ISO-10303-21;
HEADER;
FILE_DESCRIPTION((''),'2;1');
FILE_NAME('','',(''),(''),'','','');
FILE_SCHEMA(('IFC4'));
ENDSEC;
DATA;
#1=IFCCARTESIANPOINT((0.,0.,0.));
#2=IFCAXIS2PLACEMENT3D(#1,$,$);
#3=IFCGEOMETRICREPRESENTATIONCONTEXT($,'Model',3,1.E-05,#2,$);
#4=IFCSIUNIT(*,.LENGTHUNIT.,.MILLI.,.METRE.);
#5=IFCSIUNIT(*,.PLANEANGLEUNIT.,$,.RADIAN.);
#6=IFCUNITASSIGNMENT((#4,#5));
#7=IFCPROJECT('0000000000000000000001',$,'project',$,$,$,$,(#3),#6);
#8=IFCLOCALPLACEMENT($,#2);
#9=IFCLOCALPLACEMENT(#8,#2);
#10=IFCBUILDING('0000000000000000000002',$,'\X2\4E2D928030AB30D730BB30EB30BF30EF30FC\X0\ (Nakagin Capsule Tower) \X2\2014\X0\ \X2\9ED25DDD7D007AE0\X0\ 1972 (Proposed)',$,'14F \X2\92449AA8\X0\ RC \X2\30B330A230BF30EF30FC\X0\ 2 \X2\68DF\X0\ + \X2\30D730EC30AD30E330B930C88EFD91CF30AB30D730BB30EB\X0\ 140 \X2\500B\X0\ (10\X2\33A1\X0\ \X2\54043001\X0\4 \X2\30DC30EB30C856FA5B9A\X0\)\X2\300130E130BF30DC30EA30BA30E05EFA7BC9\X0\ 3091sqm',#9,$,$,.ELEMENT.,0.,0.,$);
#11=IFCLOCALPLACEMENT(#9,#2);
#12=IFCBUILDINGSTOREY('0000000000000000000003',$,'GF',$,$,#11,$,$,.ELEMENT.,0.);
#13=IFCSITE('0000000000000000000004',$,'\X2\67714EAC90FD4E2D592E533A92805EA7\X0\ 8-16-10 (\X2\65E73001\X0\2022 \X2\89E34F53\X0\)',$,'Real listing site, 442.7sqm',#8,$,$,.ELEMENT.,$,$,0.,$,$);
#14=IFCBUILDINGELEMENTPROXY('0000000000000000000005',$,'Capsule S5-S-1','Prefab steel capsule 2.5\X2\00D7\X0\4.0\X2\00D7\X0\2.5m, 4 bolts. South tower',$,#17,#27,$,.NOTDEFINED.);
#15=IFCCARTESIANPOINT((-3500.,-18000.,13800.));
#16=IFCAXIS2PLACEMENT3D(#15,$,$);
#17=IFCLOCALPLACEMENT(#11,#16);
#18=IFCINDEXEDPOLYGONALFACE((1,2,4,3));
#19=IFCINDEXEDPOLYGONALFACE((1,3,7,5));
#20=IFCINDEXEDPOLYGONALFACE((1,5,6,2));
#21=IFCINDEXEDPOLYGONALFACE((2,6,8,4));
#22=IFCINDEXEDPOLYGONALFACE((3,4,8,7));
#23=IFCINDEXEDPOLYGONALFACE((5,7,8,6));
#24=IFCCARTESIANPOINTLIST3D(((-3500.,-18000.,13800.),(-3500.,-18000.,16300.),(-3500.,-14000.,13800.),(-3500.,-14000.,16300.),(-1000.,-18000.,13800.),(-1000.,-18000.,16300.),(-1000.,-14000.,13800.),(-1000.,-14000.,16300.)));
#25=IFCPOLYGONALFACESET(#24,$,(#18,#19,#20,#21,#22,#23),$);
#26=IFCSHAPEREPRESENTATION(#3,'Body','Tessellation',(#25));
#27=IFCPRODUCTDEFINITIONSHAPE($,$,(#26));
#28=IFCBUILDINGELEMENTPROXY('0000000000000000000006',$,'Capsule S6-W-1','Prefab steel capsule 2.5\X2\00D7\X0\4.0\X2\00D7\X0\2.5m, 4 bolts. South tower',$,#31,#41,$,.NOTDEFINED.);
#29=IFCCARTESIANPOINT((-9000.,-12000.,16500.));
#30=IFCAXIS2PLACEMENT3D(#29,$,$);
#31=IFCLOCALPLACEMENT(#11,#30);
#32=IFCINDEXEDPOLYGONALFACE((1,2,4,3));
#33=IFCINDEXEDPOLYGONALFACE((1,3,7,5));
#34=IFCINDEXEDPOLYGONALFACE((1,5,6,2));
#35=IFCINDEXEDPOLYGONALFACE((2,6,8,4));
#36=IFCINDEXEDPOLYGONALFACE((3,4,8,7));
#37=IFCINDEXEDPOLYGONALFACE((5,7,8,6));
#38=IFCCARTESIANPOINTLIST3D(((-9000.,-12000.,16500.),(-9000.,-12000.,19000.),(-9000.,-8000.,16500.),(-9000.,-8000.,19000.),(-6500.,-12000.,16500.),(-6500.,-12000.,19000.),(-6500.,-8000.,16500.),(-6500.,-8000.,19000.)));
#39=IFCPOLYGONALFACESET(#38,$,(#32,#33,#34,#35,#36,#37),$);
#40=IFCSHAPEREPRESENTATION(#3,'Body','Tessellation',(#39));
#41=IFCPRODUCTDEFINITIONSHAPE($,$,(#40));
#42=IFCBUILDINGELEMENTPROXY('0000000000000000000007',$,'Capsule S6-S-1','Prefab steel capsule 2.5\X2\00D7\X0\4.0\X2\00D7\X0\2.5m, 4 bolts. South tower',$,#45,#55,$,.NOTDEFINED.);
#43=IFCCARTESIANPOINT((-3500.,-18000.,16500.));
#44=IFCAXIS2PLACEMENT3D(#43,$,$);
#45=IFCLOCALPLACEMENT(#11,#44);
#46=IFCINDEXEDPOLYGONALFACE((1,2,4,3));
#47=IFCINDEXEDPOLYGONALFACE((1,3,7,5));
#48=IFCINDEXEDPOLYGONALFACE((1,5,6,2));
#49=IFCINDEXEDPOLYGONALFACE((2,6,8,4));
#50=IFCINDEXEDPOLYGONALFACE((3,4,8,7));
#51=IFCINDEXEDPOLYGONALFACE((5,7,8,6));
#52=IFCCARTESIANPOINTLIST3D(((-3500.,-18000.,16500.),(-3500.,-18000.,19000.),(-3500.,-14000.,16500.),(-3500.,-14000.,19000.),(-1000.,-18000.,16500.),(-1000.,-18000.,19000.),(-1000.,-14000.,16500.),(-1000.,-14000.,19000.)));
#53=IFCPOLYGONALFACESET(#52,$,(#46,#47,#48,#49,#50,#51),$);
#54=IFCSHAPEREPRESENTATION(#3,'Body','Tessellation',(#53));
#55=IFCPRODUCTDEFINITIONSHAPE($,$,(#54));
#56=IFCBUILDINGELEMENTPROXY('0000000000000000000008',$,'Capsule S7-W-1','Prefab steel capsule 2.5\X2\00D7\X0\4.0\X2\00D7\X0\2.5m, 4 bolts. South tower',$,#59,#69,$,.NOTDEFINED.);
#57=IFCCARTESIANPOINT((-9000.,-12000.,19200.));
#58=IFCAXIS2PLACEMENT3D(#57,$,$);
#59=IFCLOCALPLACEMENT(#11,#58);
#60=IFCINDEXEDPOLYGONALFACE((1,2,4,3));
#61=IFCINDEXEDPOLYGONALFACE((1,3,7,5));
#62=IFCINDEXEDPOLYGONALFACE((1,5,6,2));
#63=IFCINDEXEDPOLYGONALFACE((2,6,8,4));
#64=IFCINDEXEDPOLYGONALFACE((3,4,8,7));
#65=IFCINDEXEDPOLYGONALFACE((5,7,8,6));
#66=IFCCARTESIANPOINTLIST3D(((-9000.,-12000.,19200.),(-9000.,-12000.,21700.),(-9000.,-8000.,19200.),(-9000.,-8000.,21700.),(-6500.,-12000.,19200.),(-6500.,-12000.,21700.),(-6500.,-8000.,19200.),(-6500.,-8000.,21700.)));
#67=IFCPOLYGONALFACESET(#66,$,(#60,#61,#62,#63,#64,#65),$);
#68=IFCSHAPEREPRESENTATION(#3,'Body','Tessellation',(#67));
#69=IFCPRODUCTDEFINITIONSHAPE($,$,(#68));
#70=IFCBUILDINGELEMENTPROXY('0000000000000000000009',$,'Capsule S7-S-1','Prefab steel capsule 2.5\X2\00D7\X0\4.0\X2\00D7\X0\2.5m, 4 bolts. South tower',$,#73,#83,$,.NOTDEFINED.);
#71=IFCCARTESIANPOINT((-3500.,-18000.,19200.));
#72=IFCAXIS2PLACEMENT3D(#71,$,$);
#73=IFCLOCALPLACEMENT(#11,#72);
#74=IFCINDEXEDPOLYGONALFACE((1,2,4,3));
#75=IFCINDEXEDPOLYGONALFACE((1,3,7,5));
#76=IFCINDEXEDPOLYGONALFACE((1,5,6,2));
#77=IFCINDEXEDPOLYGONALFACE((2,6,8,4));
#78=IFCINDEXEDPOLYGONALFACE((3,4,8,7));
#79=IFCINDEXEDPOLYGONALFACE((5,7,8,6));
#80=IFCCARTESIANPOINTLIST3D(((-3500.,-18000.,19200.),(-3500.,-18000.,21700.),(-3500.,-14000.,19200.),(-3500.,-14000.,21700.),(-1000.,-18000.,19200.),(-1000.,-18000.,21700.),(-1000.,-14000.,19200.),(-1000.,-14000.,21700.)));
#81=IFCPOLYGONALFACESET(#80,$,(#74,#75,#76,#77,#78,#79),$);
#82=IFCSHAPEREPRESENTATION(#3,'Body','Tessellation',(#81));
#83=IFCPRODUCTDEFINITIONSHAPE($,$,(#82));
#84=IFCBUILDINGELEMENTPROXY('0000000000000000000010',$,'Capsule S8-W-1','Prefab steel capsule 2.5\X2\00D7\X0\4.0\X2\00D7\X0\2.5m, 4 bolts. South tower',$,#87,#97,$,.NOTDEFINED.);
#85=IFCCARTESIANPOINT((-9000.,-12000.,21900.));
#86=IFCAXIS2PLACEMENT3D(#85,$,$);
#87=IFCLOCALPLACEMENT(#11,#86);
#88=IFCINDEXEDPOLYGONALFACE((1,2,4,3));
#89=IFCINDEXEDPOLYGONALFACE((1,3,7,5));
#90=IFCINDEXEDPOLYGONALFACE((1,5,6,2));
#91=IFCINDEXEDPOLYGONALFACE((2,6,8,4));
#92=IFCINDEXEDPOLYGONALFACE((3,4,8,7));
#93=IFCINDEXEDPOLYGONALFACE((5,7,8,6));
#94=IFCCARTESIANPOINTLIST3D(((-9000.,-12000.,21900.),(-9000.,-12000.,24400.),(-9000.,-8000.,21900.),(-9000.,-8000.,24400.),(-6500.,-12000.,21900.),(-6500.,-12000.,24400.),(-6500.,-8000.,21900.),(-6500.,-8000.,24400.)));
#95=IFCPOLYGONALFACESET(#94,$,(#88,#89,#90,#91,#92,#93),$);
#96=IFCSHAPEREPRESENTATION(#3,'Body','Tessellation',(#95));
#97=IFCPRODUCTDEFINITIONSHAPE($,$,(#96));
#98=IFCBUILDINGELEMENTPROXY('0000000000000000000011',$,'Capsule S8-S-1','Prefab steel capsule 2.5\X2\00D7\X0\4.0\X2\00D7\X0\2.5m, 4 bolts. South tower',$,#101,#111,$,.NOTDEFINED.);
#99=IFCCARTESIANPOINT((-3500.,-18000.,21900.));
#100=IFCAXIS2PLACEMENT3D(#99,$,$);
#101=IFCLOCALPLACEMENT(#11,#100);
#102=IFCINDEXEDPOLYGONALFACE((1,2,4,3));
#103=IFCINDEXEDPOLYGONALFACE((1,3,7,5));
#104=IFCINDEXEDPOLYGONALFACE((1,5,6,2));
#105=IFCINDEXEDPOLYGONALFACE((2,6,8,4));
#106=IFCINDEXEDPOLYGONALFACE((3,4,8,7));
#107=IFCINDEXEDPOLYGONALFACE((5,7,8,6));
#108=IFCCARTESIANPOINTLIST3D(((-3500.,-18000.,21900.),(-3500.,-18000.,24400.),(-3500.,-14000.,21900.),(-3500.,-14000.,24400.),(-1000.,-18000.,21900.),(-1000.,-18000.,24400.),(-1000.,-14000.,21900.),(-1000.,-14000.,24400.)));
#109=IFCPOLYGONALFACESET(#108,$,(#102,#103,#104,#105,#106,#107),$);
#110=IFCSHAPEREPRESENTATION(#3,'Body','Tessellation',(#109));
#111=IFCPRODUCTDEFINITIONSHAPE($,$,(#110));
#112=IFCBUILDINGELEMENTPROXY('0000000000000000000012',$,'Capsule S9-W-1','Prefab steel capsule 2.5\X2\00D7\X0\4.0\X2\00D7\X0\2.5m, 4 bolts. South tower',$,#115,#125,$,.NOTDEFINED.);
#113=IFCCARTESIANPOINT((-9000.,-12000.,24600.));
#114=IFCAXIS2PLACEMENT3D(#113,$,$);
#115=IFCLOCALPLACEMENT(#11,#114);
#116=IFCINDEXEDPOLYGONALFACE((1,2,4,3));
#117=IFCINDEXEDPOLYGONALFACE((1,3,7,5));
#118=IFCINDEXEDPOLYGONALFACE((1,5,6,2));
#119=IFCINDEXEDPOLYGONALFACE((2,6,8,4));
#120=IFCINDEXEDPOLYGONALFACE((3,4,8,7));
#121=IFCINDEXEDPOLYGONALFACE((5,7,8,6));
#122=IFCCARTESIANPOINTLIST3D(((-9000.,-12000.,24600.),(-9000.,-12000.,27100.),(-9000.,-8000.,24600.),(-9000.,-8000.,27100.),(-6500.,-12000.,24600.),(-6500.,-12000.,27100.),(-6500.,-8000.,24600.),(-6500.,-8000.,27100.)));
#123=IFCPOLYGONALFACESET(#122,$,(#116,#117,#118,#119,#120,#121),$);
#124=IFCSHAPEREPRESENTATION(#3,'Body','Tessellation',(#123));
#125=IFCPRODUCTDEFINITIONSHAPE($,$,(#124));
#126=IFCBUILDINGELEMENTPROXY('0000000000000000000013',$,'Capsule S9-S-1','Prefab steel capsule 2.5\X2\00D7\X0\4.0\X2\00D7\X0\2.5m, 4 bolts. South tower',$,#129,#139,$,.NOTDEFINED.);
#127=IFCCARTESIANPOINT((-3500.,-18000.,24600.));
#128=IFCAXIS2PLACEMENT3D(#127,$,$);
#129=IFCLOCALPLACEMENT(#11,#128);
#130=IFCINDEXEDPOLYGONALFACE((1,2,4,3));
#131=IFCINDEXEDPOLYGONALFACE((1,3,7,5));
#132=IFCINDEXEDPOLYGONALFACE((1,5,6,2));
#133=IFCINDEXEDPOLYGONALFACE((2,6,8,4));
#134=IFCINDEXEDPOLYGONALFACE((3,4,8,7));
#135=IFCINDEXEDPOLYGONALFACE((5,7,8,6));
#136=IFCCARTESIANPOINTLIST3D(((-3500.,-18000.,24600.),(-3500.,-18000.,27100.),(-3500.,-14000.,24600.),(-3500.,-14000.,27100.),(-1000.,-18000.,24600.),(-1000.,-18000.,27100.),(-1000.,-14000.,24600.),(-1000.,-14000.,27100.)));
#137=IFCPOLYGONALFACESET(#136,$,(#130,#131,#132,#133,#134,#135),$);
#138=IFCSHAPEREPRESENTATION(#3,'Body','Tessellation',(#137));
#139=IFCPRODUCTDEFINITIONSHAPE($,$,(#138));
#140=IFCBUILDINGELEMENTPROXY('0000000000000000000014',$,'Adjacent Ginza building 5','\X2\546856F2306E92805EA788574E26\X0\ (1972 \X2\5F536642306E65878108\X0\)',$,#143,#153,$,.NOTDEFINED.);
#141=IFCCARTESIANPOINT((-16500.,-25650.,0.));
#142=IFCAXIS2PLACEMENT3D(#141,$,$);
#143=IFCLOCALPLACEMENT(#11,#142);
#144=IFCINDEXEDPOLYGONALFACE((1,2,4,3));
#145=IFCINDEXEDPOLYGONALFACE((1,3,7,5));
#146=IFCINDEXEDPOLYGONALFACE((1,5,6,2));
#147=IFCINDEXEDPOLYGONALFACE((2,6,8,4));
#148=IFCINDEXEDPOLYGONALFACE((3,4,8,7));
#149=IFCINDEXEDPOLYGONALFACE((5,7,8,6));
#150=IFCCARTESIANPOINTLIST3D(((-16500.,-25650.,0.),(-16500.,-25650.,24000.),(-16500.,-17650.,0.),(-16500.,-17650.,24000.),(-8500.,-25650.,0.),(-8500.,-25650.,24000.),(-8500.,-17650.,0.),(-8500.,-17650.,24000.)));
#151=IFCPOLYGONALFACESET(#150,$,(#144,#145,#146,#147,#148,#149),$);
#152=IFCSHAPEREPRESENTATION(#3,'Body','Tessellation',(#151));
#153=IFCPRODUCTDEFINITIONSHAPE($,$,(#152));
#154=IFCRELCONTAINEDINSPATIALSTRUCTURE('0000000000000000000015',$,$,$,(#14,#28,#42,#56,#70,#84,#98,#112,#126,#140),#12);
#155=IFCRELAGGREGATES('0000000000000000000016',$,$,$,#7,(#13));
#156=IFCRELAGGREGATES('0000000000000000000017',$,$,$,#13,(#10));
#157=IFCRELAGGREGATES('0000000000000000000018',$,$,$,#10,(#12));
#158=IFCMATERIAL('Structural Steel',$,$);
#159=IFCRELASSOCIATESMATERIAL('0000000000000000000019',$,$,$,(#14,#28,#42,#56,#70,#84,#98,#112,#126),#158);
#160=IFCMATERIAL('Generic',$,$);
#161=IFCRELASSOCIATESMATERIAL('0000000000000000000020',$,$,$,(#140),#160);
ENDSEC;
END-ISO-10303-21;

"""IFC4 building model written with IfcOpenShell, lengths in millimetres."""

from ifc_helpers import new_model, si_unit, frame, frame_2d, origin, place, context, project, spatial, rectangle, extrude, material, element, save


model = new_model("IFC4")

# Units and contexts
model_context = context("Model", 3, precision=1e-05, world=origin())
ifc_project = project(units=[si_unit("LENGTHUNIT", "METRE", prefix="MILLI"), si_unit("PLANEANGLEUNIT", "RADIAN")], contexts=[model_context])

# Site, building, storey
site_placement = place(None, origin())
site = spatial("IfcSite", under=ifc_project, at=site_placement, Name="東京都中央区銀座 8-16-10 (旧、2022 解体)", ObjectType="Real listing site, 442.7sqm", CompositionType="ELEMENT", RefElevation=0.0)
building_placement = place(site_placement, origin())
building = spatial("IfcBuilding", under=site, at=building_placement, Name="中銀カプセルタワー (Nakagin Capsule Tower) — 黒川紀章 1972 (Proposed)", ObjectType="14F 鉄骨 RC コアタワー 2 棟 + プレキャスト軽量カプセル 140 個 (10㎡ 各、4 ボルト固定)、メタボリズム建築 3091sqm", CompositionType="ELEMENT", ElevationOfRefHeight=0.0, ElevationOfTerrain=0.0)
storey_placement = place(building_placement, origin())
storey = spatial("IfcBuildingStorey", under=building, at=storey_placement, Name="GF", CompositionType="ELEMENT", Elevation=0.0)

# Shared definitions
ifc_material_1 = material(Name="Structural Steel")

# Building element proxies
proxy_1_placement = place(storey_placement, frame((-3500.0, -18000.0, 13800.0)))
element("IfcBuildingElementProxy", 1, at=proxy_1_placement, inside=storey, material=ifc_material_1, Name="Capsule S5-S-1", Description="Prefab steel capsule 2.5×4.0×2.5m, 4 bolts. South tower", PredefinedType="NOTDEFINED", context=model_context, shape_type="SweptSolid", body=[
    extrude(rectangle(XDim=2500.0, YDim=4000.0, at=frame_2d((1250.0, 2000.0))), frame((-3500.0, -18000.0, 13800.0)), (0.0, 0.0, 1.0), 2500.0),
])
proxy_2_placement = place(storey_placement, frame((-9000.0, -12000.0, 16500.0)))
element("IfcBuildingElementProxy", 2, at=proxy_2_placement, inside=storey, material=ifc_material_1, Name="Capsule S6-W-1", Description="Prefab steel capsule 2.5×4.0×2.5m, 4 bolts. South tower", PredefinedType="NOTDEFINED", context=model_context, shape_type="SweptSolid", body=[
    extrude(rectangle(XDim=2500.0, YDim=4000.0, at=frame_2d((1250.0, 2000.0))), frame((-9000.0, -12000.0, 16500.0)), (0.0, 0.0, 1.0), 2500.0),
])
proxy_3_placement = place(storey_placement, frame((-3500.0, -18000.0, 16500.0)))
element("IfcBuildingElementProxy", 3, at=proxy_3_placement, inside=storey, material=ifc_material_1, Name="Capsule S6-S-1", Description="Prefab steel capsule 2.5×4.0×2.5m, 4 bolts. South tower", PredefinedType="NOTDEFINED", context=model_context, shape_type="SweptSolid", body=[
    extrude(rectangle(XDim=2500.0, YDim=4000.0, at=frame_2d((1250.0, 2000.0))), frame((-3500.0, -18000.0, 16500.0)), (0.0, 0.0, 1.0), 2500.0),
])
proxy_4_placement = place(storey_placement, frame((-9000.0, -12000.0, 19200.0)))
element("IfcBuildingElementProxy", 4, at=proxy_4_placement, inside=storey, material=ifc_material_1, Name="Capsule S7-W-1", Description="Prefab steel capsule 2.5×4.0×2.5m, 4 bolts. South tower", PredefinedType="NOTDEFINED", context=model_context, shape_type="SweptSolid", body=[
    extrude(rectangle(XDim=2500.0, YDim=4000.0, at=frame_2d((1250.0, 2000.0))), frame((-9000.0, -12000.0, 19200.0)), (0.0, 0.0, 1.0), 2500.0),
])
proxy_5_placement = place(storey_placement, frame((-3500.0, -18000.0, 19200.0)))
element("IfcBuildingElementProxy", 5, at=proxy_5_placement, inside=storey, material=ifc_material_1, Name="Capsule S7-S-1", Description="Prefab steel capsule 2.5×4.0×2.5m, 4 bolts. South tower", PredefinedType="NOTDEFINED", context=model_context, shape_type="SweptSolid", body=[
    extrude(rectangle(XDim=2500.0, YDim=4000.0, at=frame_2d((1250.0, 2000.0))), frame((-3500.0, -18000.0, 19200.0)), (0.0, 0.0, 1.0), 2500.0),
])
proxy_6_placement = place(storey_placement, frame((-9000.0, -12000.0, 21900.0)))
element("IfcBuildingElementProxy", 6, at=proxy_6_placement, inside=storey, material=ifc_material_1, Name="Capsule S8-W-1", Description="Prefab steel capsule 2.5×4.0×2.5m, 4 bolts. South tower", PredefinedType="NOTDEFINED", context=model_context, shape_type="SweptSolid", body=[
    extrude(rectangle(XDim=2500.0, YDim=4000.0, at=frame_2d((1250.0, 2000.0))), frame((-9000.0, -12000.0, 21900.0)), (0.0, 0.0, 1.0), 2500.0),
])
proxy_7_placement = place(storey_placement, frame((-3500.0, -18000.0, 21900.0)))
element("IfcBuildingElementProxy", 7, at=proxy_7_placement, inside=storey, material=ifc_material_1, Name="Capsule S8-S-1", Description="Prefab steel capsule 2.5×4.0×2.5m, 4 bolts. South tower", PredefinedType="NOTDEFINED", context=model_context, shape_type="SweptSolid", body=[
    extrude(rectangle(XDim=2500.0, YDim=4000.0, at=frame_2d((1250.0, 2000.0))), frame((-3500.0, -18000.0, 21900.0)), (0.0, 0.0, 1.0), 2500.0),
])
proxy_8_placement = place(storey_placement, frame((-9000.0, -12000.0, 24600.0)))
element("IfcBuildingElementProxy", 8, at=proxy_8_placement, inside=storey, material=ifc_material_1, Name="Capsule S9-W-1", Description="Prefab steel capsule 2.5×4.0×2.5m, 4 bolts. South tower", PredefinedType="NOTDEFINED", context=model_context, shape_type="SweptSolid", body=[
    extrude(rectangle(XDim=2500.0, YDim=4000.0, at=frame_2d((1250.0, 2000.0))), frame((-9000.0, -12000.0, 24600.0)), (0.0, 0.0, 1.0), 2500.0),
])
proxy_9_placement = place(storey_placement, frame((-3500.0, -18000.0, 24600.0)))
element("IfcBuildingElementProxy", 9, at=proxy_9_placement, inside=storey, material=ifc_material_1, Name="Capsule S9-S-1", Description="Prefab steel capsule 2.5×4.0×2.5m, 4 bolts. South tower", PredefinedType="NOTDEFINED", context=model_context, shape_type="SweptSolid", body=[
    extrude(rectangle(XDim=2500.0, YDim=4000.0, at=frame_2d((1250.0, 2000.0))), frame((-3500.0, -18000.0, 24600.0)), (0.0, 0.0, 1.0), 2500.0),
])
ifc_material_2 = material(Name="Generic")
proxy_10_placement = place(storey_placement, frame((-16500.0, -25650.0, 0.0)))
element("IfcBuildingElementProxy", 10, at=proxy_10_placement, inside=storey, material=ifc_material_2, Name="Adjacent Ginza building 5", Description="周囲の銀座街並 (1972 当時の文脈)", PredefinedType="NOTDEFINED", context=model_context, shape_type="SweptSolid", body=[
    extrude(rectangle(XDim=8000.0, YDim=8000.0, at=frame_2d((4000.0, 4000.0))), frame((-16500.0, -25650.0, 0.0)), (0.0, 0.0, 1.0), 24000.0),
])

save(model, "model.ifc")
